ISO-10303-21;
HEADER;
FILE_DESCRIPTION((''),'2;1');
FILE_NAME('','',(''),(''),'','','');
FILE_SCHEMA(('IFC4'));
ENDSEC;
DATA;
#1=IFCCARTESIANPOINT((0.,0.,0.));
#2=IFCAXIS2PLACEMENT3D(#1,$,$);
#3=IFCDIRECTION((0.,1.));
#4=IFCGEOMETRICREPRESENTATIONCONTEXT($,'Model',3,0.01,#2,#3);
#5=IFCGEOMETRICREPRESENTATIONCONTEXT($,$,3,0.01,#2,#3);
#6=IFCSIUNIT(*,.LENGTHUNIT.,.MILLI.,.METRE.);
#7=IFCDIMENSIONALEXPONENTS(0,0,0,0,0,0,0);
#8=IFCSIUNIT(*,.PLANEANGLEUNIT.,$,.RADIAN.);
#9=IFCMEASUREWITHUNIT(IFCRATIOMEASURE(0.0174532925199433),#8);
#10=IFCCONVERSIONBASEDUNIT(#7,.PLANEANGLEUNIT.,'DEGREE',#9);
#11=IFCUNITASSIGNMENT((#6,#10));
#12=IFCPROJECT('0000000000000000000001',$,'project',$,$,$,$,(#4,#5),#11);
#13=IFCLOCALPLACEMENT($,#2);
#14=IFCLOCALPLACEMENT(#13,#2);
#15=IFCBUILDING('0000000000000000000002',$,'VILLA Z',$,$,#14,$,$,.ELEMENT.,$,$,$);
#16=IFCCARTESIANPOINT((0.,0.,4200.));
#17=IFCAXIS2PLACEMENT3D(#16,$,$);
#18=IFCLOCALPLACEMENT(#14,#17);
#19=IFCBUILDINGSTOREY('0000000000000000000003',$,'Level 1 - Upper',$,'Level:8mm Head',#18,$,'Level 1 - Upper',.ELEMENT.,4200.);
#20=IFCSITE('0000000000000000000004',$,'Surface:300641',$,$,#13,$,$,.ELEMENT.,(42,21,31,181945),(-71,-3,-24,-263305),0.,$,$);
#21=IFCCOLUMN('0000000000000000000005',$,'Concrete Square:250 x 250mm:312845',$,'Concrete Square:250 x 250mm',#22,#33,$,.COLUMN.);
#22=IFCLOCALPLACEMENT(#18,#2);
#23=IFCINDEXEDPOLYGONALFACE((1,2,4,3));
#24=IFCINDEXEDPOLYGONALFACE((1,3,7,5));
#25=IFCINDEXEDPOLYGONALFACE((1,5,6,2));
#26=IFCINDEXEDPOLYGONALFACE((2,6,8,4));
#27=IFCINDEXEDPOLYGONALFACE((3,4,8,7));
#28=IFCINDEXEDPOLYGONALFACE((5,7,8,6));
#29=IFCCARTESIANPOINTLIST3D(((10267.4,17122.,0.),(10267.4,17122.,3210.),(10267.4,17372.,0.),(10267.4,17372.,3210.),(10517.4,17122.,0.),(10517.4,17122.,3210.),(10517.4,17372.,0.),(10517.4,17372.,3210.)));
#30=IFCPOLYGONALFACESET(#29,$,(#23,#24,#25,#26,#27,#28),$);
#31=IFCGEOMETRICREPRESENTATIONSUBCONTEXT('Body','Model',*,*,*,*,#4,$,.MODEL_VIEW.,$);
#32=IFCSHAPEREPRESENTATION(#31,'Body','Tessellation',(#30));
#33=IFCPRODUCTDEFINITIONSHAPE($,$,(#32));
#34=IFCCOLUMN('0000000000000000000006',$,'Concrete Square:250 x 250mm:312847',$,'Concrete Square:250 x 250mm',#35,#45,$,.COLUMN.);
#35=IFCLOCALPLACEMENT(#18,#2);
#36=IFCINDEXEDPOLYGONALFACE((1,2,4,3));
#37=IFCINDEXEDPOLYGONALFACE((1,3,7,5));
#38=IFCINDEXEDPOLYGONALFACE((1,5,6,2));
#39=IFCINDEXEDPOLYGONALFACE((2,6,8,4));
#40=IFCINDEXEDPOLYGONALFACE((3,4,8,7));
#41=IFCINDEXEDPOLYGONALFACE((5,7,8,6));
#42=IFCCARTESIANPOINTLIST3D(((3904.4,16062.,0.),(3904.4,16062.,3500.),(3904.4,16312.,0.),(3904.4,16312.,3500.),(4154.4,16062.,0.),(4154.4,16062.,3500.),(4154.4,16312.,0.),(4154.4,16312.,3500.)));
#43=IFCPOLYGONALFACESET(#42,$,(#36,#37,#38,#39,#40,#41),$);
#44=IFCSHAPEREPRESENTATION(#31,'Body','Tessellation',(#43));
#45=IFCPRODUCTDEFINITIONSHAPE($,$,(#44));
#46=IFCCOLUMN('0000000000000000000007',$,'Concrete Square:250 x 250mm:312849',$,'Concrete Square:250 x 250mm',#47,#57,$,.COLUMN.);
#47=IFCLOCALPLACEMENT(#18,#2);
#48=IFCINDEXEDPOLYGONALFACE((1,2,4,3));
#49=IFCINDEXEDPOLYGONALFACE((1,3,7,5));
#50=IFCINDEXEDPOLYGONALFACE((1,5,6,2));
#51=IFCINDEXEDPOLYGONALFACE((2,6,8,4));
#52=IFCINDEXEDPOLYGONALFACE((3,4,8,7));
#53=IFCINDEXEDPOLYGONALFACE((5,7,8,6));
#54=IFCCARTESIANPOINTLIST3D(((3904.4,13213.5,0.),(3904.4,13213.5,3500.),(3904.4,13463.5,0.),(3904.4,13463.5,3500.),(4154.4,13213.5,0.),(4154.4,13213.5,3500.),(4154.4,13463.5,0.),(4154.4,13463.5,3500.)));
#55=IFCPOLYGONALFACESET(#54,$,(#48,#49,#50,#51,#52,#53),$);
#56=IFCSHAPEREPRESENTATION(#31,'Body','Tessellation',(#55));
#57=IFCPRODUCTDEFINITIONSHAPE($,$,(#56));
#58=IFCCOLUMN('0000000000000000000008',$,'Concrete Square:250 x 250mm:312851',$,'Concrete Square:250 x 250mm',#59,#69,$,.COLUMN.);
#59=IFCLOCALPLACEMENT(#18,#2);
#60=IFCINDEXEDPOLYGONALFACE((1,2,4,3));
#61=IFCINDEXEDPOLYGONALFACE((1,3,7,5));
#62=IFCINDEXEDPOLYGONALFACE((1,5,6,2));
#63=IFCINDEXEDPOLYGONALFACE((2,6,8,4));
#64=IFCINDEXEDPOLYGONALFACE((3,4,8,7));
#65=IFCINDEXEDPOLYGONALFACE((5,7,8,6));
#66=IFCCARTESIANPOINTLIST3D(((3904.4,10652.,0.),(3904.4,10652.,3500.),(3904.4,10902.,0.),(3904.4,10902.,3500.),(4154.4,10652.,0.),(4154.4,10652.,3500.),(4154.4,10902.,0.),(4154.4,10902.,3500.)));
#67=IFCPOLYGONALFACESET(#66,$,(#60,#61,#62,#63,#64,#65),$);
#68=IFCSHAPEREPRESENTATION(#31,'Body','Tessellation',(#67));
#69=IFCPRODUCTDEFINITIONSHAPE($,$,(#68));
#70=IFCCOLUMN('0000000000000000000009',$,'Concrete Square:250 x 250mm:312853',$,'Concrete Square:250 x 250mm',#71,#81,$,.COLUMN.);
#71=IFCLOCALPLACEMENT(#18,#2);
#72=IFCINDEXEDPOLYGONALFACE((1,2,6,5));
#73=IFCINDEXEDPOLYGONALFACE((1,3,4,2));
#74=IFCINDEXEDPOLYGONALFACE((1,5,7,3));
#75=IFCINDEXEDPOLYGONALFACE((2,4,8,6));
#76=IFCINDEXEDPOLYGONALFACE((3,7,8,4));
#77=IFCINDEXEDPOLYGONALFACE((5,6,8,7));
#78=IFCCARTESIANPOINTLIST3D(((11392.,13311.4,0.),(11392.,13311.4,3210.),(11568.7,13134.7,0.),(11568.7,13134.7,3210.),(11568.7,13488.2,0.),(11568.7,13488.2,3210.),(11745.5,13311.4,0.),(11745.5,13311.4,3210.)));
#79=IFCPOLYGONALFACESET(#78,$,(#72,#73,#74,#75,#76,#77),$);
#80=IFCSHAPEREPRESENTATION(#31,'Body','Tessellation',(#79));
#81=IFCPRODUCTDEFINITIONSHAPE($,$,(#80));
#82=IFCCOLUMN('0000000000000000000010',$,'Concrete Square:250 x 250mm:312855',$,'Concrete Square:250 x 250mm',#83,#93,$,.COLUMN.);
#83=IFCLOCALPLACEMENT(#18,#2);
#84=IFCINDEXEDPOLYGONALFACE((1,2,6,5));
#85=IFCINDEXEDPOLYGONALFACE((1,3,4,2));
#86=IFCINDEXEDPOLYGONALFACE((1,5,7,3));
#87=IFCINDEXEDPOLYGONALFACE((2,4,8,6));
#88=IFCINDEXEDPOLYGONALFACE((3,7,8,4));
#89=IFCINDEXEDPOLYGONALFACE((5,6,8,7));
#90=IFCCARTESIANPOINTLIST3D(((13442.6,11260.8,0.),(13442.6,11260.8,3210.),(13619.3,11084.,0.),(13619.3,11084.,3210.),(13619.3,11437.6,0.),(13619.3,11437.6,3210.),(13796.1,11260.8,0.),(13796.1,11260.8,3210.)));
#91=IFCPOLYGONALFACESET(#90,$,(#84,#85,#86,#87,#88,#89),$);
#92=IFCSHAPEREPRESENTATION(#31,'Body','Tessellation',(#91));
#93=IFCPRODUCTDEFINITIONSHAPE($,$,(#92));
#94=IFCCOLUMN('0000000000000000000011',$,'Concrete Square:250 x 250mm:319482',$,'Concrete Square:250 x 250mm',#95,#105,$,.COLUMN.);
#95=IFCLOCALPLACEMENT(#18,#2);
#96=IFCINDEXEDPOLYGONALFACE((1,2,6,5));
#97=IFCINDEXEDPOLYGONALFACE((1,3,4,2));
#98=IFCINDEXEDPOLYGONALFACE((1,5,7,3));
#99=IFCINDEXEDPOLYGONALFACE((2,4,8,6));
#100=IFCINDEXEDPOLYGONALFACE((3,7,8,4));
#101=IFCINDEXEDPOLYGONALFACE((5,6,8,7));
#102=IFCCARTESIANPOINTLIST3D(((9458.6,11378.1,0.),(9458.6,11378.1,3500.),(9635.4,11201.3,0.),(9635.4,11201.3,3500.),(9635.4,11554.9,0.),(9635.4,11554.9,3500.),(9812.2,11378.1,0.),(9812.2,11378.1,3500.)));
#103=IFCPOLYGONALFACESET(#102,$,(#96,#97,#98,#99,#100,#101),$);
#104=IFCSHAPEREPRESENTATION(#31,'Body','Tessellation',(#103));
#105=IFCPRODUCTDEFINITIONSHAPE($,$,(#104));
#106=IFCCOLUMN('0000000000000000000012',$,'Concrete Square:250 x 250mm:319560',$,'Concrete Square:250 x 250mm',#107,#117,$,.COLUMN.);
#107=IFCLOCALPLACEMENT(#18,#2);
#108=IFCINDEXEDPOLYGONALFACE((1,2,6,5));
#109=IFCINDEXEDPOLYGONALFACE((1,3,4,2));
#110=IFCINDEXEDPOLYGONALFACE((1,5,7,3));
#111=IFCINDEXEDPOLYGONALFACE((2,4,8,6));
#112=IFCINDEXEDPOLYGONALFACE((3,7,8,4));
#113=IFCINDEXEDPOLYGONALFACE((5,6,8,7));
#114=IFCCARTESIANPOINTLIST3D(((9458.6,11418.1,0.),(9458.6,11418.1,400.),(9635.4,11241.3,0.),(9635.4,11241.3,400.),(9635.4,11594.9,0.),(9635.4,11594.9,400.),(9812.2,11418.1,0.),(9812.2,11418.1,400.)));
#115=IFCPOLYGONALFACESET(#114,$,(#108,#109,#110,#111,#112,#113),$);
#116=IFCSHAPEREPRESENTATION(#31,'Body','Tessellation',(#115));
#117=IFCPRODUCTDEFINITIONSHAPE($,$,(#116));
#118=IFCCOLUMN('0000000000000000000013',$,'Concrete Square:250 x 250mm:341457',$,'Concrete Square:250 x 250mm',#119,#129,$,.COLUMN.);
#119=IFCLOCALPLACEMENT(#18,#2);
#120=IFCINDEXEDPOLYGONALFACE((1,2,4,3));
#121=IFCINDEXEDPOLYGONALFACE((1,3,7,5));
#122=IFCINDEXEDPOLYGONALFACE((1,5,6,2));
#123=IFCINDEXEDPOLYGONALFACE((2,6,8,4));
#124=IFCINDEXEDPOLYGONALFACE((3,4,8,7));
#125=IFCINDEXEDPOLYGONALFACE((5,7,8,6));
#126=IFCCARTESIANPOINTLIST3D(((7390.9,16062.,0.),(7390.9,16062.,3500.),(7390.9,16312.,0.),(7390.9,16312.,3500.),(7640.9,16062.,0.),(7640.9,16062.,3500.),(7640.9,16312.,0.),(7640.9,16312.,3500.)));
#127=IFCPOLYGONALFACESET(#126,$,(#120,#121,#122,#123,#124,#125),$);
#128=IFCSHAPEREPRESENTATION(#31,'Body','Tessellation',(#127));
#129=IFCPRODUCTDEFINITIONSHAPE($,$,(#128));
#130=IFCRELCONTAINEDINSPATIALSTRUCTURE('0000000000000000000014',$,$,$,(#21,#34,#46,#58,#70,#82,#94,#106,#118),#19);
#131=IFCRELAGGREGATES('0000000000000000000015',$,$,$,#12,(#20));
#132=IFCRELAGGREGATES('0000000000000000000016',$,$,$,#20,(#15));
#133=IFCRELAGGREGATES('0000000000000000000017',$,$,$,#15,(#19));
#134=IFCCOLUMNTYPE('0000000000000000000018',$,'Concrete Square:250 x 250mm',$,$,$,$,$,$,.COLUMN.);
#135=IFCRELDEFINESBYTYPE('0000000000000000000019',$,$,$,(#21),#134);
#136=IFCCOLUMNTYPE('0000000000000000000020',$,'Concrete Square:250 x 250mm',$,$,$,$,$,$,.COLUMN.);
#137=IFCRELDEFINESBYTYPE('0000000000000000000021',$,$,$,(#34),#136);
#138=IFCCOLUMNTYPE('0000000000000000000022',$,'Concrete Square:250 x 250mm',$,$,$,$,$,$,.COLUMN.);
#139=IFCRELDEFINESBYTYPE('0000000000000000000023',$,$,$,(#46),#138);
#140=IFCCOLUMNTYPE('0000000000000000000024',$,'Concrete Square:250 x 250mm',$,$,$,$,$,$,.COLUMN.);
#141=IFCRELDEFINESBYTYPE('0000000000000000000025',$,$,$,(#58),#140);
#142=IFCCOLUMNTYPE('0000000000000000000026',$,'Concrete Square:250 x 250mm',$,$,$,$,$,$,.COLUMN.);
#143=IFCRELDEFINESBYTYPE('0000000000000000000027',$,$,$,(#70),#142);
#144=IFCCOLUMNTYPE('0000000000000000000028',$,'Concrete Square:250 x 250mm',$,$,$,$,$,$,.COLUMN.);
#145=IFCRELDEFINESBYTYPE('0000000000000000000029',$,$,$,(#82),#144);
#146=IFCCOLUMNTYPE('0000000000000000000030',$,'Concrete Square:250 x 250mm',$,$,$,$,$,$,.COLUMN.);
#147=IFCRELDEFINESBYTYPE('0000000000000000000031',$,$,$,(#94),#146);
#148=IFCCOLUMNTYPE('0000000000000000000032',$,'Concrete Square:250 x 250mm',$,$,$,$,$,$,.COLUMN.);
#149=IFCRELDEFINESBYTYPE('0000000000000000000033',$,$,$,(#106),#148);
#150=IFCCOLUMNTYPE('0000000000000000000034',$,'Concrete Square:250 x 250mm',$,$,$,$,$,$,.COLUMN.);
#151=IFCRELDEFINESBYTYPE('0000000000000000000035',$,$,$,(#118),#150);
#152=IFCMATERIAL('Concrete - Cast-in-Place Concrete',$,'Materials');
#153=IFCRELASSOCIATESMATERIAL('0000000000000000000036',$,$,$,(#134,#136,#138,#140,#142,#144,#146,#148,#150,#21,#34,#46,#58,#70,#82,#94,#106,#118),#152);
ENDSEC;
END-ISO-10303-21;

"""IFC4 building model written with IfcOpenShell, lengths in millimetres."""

from ifc_helpers import new_model, entity, si_unit, converted_unit, direction, frame, frame_2d, origin, origin_2d_with_axis, place, context, subcontext, project, spatial, rectangle, extrude, source, transform, mapped, material, material_profile, profile_set, profile_usage, type_object, type_shapes, element, save


model = new_model("IFC4")

# Units and contexts
model_context = context("Model", 3, precision=0.01, world=origin(), true_north=direction((0.0, 1.0)))
context_of_model = context(None, 3, precision=0.01, world=origin(), true_north=direction((0.0, 1.0)))
body_context = subcontext(model_context, "Body", "Model", "MODEL_VIEW")
ifc_project = project(units=[si_unit("LENGTHUNIT", "METRE", prefix="MILLI"), converted_unit("PLANEANGLEUNIT", "DEGREE", entity("IfcRatioMeasure", 0.0174532925199433), si_unit("PLANEANGLEUNIT", "RADIAN"), dimensions=[0, 0, 0, 0, 0, 0, 0])], contexts=[model_context, context_of_model])

# Site, building, storey
site_placement = place(None, origin())
site = spatial("IfcSite", under=ifc_project, at=site_placement, Name="Surface:300641", CompositionType="ELEMENT", RefLatitude=(42, 21, 31, 181945), RefLongitude=(-71, -3, -24, -263305), RefElevation=0.0)
building_placement = place(site_placement, origin())
building = spatial("IfcBuilding", under=site, at=building_placement, Name="VILLA Z", CompositionType="ELEMENT")
storey_placement = place(building_placement, frame((0.0, 0.0, 4200.0)))
storey = spatial("IfcBuildingStorey", under=building, at=storey_placement, Name="Level 1 - Upper", ObjectType="Level:8mm Head", LongName="Level 1 - Upper", CompositionType="ELEMENT", Elevation=4200.0)

# Columns
ifc_material = material(Name="Concrete - Cast-in-Place Concrete", Category="Materials")
ifc_material_profile_1 = material_profile(ifc_material, rectangle(XDim=250.0, YDim=250.0, at=frame_2d((0.0, 0.0), x_axis=(1.0, 0.0))), Name="250 x 250mm")
ifc_profile_set_1 = profile_set([ifc_material_profile_1], Name="250 x 250mm")
ifc_profile_usage_1 = profile_usage(ifc_profile_set_1)
column_type_1 = type_object("IfcColumnType", Name="Concrete Square:250 x 250mm", PredefinedType="COLUMN", material=ifc_profile_set_1)
shared_shape_1 = source(origin(), body_context, "Body", "SweptSolid", [
    extrude(rectangle(XDim=250.0, YDim=250.0, at=origin_2d_with_axis()), frame((10392.4, 17247.0, 4200.0), z_axis=(0.0, 0.0, 1.0), x_axis=(0.0, -1.0, 0.0)), (0.0, 0.0, 1.0), 3210.0),
])
type_shapes(column_type_1, [shared_shape_1])
column_1_placement = place(storey_placement, frame((0.0, 0.0, -4200.0)))
element("IfcColumn", 1, at=column_1_placement, inside=storey, type_object=column_type_1, material=ifc_profile_usage_1, Name="Concrete Square:250 x 250mm:312845", ObjectType="Concrete Square:250 x 250mm", PredefinedType="COLUMN", context=body_context, shape_type="MappedRepresentation", body=[
    mapped(shared_shape_1, transform((0.0, 0.0, 0.0), scale=1.0)),
])
ifc_profile_usage_2 = profile_usage(ifc_profile_set_1)
column_type_2 = type_object("IfcColumnType", Name="Concrete Square:250 x 250mm", PredefinedType="COLUMN", material=ifc_profile_set_1)
shared_shape_2 = source(origin(), body_context, "Body", "SweptSolid", [
    extrude(rectangle(XDim=250.0, YDim=250.0, at=frame_2d((0.0, 0.0), x_axis=(1.0, 0.0))), frame((4029.4, 16187.0, 4200.0), z_axis=(0.0, 0.0, 1.0), x_axis=(0.0, -1.0, 0.0)), (0.0, 0.0, 1.0), 3500.0),
])
type_shapes(column_type_2, [shared_shape_2])
column_2_placement = place(storey_placement, frame((0.0, 0.0, -4200.0)))
element("IfcColumn", 2, at=column_2_placement, inside=storey, type_object=column_type_2, material=ifc_profile_usage_2, Name="Concrete Square:250 x 250mm:312847", ObjectType="Concrete Square:250 x 250mm", PredefinedType="COLUMN", context=body_context, shape_type="MappedRepresentation", body=[
    mapped(shared_shape_2, transform((0.0, 0.0, 0.0), scale=1.0)),
])
ifc_profile_usage_3 = profile_usage(ifc_profile_set_1)
column_type_3 = type_object("IfcColumnType", Name="Concrete Square:250 x 250mm", PredefinedType="COLUMN", material=ifc_profile_set_1)
shared_shape_3 = source(origin(), body_context, "Body", "SweptSolid", [
    extrude(rectangle(XDim=250.0, YDim=250.0, at=frame_2d((0.0, 0.0), x_axis=(1.0, 0.0))), frame((4029.4, 13338.5, 4200.0), z_axis=(0.0, 0.0, 1.0), x_axis=(0.0, -1.0, 0.0)), (0.0, 0.0, 1.0), 3500.0),
])
type_shapes(column_type_3, [shared_shape_3])
column_3_placement = place(storey_placement, frame((0.0, 0.0, -4200.0)))
element("IfcColumn", 3, at=column_3_placement, inside=storey, type_object=column_type_3, material=ifc_profile_usage_3, Name="Concrete Square:250 x 250mm:312849", ObjectType="Concrete Square:250 x 250mm", PredefinedType="COLUMN", context=body_context, shape_type="MappedRepresentation", body=[
    mapped(shared_shape_3, transform((0.0, 0.0, 0.0), scale=1.0)),
])
ifc_profile_usage_4 = profile_usage(ifc_profile_set_1)
column_type_4 = type_object("IfcColumnType", Name="Concrete Square:250 x 250mm", PredefinedType="COLUMN", material=ifc_profile_set_1)
shared_shape_4 = source(origin(), body_context, "Body", "SweptSolid", [
    extrude(rectangle(XDim=250.0, YDim=250.0, at=frame_2d((0.0, 0.0), x_axis=(1.0, 0.0))), frame((4029.4, 10777.0, 4200.0), z_axis=(0.0, 0.0, 1.0), x_axis=(0.0, -1.0, 0.0)), (0.0, 0.0, 1.0), 3500.0),
])
type_shapes(column_type_4, [shared_shape_4])
column_4_placement = place(storey_placement, frame((0.0, 0.0, -4200.0)))
element("IfcColumn", 4, at=column_4_placement, inside=storey, type_object=column_type_4, material=ifc_profile_usage_4, Name="Concrete Square:250 x 250mm:312851", ObjectType="Concrete Square:250 x 250mm", PredefinedType="COLUMN", context=body_context, shape_type="MappedRepresentation", body=[
    mapped(shared_shape_4, transform((0.0, 0.0, 0.0), scale=1.0)),
])
ifc_profile_usage_5 = profile_usage(ifc_profile_set_1)
column_type_5 = type_object("IfcColumnType", Name="Concrete Square:250 x 250mm", PredefinedType="COLUMN", material=ifc_profile_set_1)
shared_shape_5 = source(origin(), body_context, "Body", "SweptSolid", [
    extrude(rectangle(XDim=250.0, YDim=250.0, at=origin_2d_with_axis()), frame((11568.7, 13311.4, 4200.0), z_axis=(0.0, 0.0, 1.0), x_axis=(-0.707107, 0.707107, 0.0)), (0.0, 0.0, 1.0), 3210.0),
])
type_shapes(column_type_5, [shared_shape_5])
column_5_placement = place(storey_placement, frame((0.0, 0.0, -4200.0)))
element("IfcColumn", 5, at=column_5_placement, inside=storey, type_object=column_type_5, material=ifc_profile_usage_5, Name="Concrete Square:250 x 250mm:312853", ObjectType="Concrete Square:250 x 250mm", PredefinedType="COLUMN", context=body_context, shape_type="MappedRepresentation", body=[
    mapped(shared_shape_5, transform((0.0, 0.0, 0.0), scale=1.0)),
])
ifc_profile_usage_6 = profile_usage(ifc_profile_set_1)
column_type_6 = type_object("IfcColumnType", Name="Concrete Square:250 x 250mm", PredefinedType="COLUMN", material=ifc_profile_set_1)
shared_shape_6 = source(origin(), body_context, "Body", "SweptSolid", [
    extrude(rectangle(XDim=250.0, YDim=250.0, at=frame_2d((0.0, 0.0), x_axis=(1.0, 0.0))), frame((13619.3, 11260.8, 4200.0), z_axis=(0.0, 0.0, 1.0), x_axis=(-0.707107, 0.707107, 0.0)), (0.0, 0.0, 1.0), 3210.0),
])
type_shapes(column_type_6, [shared_shape_6])
column_6_placement = place(storey_placement, frame((0.0, 0.0, -4200.0)))
element("IfcColumn", 6, at=column_6_placement, inside=storey, type_object=column_type_6, material=ifc_profile_usage_6, Name="Concrete Square:250 x 250mm:312855", ObjectType="Concrete Square:250 x 250mm", PredefinedType="COLUMN", context=body_context, shape_type="MappedRepresentation", body=[
    mapped(shared_shape_6, transform((0.0, 0.0, 0.0), scale=1.0)),
])
ifc_profile_usage_7 = profile_usage(ifc_profile_set_1)
column_type_7 = type_object("IfcColumnType", Name="Concrete Square:250 x 250mm", PredefinedType="COLUMN", material=ifc_profile_set_1)
shared_shape_7 = source(origin(), body_context, "Body", "SweptSolid", [
    extrude(rectangle(XDim=250.0, YDim=250.0, at=frame_2d((0.0, 0.0), x_axis=(1.0, 0.0))), frame((9635.4, 11378.1, 4200.0), z_axis=(0.0, 0.0, 1.0), x_axis=(-0.707107, 0.707107, 0.0)), (0.0, 0.0, 1.0), 3500.0),
])
type_shapes(column_type_7, [shared_shape_7])
column_7_placement = place(storey_placement, frame((0.0, 0.0, -4200.0)))
element("IfcColumn", 7, at=column_7_placement, inside=storey, type_object=column_type_7, material=ifc_profile_usage_7, Name="Concrete Square:250 x 250mm:319482", ObjectType="Concrete Square:250 x 250mm", PredefinedType="COLUMN", context=body_context, shape_type="MappedRepresentation", body=[
    mapped(shared_shape_7, transform((0.0, 0.0, 0.0), scale=1.0)),
])
ifc_profile_usage_8 = profile_usage(ifc_profile_set_1)
column_type_8 = type_object("IfcColumnType", Name="Concrete Square:250 x 250mm", PredefinedType="COLUMN", material=ifc_profile_set_1)
shared_shape_8 = source(origin(), body_context, "Body", "SweptSolid", [
    extrude(rectangle(XDim=250.0, YDim=250.0, at=frame_2d((0.0, 0.0), x_axis=(1.0, 0.0))), frame((9635.4, 11418.1, 4200.0), z_axis=(0.0, 0.0, 1.0), x_axis=(-0.707107, 0.707107, 0.0)), (0.0, 0.0, 1.0), 400.0),
])
type_shapes(column_type_8, [shared_shape_8])
column_8_placement = place(storey_placement, frame((0.0, 0.0, -4200.0)))
element("IfcColumn", 8, at=column_8_placement, inside=storey, type_object=column_type_8, material=ifc_profile_usage_8, Name="Concrete Square:250 x 250mm:319560", ObjectType="Concrete Square:250 x 250mm", PredefinedType="COLUMN", context=body_context, shape_type="MappedRepresentation", body=[
    mapped(shared_shape_8, transform((0.0, 0.0, 0.0), scale=1.0)),
])
ifc_profile_usage_9 = profile_usage(ifc_profile_set_1)
column_type_9 = type_object("IfcColumnType", Name="Concrete Square:250 x 250mm", PredefinedType="COLUMN", material=ifc_profile_set_1)
shared_shape_9 = source(origin(), body_context, "Body", "SweptSolid", [
    extrude(rectangle(XDim=250.0, YDim=250.0, at=frame_2d((0.0, 0.0), x_axis=(1.0, 0.0))), frame((7515.9, 16187.0, 4200.0), z_axis=(0.0, 0.0, 1.0), x_axis=(0.0, -1.0, 0.0)), (0.0, 0.0, 1.0), 3500.0),
])
type_shapes(column_type_9, [shared_shape_9])
column_9_placement = place(storey_placement, frame((0.0, 0.0, -4200.0)))
element("IfcColumn", 9, at=column_9_placement, inside=storey, type_object=column_type_9, material=ifc_profile_usage_9, Name="Concrete Square:250 x 250mm:341457", ObjectType="Concrete Square:250 x 250mm", PredefinedType="COLUMN", context=body_context, shape_type="MappedRepresentation", body=[
    mapped(shared_shape_9, transform((0.0, 0.0, 0.0), scale=1.0)),
])

save(model, "model.ifc")
